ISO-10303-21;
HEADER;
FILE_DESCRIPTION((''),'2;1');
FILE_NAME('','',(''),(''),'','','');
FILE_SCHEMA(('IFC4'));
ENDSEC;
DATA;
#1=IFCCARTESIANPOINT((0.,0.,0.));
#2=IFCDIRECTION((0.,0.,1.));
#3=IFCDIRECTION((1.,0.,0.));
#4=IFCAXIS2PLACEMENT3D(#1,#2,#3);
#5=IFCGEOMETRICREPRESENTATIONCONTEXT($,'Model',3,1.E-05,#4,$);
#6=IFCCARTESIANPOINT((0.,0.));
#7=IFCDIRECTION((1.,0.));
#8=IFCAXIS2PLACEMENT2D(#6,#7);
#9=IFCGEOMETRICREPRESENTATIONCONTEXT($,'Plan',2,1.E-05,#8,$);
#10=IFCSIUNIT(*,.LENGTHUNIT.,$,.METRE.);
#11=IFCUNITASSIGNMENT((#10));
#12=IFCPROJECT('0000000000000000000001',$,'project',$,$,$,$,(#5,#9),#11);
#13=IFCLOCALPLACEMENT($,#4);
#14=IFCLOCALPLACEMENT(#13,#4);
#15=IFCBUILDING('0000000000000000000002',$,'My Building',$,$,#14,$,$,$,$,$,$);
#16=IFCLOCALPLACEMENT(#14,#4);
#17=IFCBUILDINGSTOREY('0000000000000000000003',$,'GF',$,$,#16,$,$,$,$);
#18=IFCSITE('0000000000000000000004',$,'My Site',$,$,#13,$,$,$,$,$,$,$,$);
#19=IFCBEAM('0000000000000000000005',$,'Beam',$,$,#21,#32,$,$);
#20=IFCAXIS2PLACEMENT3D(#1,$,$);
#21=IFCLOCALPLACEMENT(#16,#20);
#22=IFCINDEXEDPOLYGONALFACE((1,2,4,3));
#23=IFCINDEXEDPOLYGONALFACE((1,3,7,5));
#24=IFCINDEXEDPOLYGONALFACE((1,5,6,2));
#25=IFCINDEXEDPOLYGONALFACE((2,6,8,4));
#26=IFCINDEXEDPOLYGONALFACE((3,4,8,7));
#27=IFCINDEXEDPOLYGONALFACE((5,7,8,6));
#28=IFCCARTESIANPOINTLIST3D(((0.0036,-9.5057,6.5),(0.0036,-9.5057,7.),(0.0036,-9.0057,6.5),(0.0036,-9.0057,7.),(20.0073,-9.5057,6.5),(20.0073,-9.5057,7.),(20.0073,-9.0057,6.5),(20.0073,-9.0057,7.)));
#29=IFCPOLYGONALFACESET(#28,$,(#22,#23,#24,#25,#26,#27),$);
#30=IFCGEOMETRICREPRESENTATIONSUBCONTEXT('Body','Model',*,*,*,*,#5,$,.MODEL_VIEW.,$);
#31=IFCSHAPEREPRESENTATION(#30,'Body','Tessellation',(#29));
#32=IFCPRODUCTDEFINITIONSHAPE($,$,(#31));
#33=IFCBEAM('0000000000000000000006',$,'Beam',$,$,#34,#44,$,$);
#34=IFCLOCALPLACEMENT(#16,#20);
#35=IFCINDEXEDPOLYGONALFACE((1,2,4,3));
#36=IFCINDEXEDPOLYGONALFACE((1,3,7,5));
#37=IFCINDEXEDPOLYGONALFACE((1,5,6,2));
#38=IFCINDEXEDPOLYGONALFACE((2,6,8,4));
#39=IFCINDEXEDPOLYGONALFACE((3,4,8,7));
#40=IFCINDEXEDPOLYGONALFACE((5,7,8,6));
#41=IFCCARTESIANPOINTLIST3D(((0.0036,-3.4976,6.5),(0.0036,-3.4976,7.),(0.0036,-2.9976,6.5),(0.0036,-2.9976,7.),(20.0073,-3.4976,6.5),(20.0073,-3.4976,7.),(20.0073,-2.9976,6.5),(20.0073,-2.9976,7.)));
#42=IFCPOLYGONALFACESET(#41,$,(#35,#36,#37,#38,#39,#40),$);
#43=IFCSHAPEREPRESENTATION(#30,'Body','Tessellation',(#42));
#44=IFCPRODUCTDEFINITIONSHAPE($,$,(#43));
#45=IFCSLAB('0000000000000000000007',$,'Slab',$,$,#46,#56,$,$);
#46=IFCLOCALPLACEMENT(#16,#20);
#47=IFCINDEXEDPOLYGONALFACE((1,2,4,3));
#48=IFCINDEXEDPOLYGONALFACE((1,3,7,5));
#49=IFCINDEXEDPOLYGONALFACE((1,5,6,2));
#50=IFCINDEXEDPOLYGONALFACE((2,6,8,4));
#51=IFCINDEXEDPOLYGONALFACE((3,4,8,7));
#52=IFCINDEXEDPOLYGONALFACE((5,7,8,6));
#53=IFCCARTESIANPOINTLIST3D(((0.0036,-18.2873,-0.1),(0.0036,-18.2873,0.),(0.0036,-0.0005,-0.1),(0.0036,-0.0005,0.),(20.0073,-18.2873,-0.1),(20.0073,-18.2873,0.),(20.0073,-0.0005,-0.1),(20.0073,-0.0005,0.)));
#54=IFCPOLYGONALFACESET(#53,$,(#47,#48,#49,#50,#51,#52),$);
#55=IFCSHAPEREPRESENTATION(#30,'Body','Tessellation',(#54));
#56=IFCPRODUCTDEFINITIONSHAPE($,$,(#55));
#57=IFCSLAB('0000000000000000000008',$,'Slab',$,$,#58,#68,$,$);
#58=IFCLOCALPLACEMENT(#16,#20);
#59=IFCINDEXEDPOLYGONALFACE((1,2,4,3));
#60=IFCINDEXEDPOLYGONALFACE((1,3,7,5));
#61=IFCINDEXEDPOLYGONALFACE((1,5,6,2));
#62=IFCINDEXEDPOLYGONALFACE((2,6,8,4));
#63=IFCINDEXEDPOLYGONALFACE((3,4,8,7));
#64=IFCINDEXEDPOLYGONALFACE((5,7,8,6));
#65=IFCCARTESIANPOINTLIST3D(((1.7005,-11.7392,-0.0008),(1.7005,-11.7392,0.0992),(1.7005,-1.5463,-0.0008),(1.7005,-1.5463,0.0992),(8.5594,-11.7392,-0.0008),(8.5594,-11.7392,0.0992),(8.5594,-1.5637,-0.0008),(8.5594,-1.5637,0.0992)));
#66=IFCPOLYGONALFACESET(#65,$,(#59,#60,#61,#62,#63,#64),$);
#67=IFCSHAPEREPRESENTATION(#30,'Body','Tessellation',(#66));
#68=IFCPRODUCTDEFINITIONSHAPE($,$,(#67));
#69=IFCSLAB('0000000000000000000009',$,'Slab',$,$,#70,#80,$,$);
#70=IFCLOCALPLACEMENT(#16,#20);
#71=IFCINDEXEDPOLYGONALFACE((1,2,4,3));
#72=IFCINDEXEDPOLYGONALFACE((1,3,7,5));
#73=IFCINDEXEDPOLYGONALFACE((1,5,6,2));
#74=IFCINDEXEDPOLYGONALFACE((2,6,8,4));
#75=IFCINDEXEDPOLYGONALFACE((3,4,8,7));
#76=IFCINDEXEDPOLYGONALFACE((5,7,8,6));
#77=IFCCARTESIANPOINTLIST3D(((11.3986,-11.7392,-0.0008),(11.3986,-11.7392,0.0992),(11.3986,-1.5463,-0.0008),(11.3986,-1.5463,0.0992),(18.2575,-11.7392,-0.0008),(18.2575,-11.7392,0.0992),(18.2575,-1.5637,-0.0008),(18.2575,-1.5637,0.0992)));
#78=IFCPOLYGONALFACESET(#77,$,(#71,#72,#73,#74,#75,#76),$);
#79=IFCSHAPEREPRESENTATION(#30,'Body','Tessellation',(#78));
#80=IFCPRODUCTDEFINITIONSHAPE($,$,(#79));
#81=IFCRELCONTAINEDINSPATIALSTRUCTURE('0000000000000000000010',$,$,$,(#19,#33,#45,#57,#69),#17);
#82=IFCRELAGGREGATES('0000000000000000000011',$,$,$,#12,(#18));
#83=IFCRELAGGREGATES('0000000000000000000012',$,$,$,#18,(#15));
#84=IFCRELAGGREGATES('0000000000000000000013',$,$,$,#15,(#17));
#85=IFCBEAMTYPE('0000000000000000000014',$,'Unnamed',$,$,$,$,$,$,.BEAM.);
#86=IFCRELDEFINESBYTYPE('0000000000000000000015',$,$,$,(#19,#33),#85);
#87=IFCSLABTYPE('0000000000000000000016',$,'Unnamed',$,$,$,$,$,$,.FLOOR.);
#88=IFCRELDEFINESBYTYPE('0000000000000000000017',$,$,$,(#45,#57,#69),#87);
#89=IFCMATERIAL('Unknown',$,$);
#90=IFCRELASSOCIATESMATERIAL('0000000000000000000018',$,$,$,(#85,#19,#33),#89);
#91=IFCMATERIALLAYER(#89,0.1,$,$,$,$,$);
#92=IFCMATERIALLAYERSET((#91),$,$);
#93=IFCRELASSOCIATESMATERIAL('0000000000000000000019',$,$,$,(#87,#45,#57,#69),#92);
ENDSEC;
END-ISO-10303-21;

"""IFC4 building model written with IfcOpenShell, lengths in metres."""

from ifc_helpers import new_model, si_unit, frame, origin_with_axes, origin_2d_with_axis, place, context, subcontext, project, spatial, indexed_curve, rectangle, outline, extrude, material, layer, layer_set, layer_usage, material_profile, profile_set, profile_usage, type_object, element, save


model = new_model("IFC4")

# Units and contexts
model_context = context("Model", 3, precision=1e-05, world=origin_with_axes())
plan_context = context("Plan", 2, precision=1e-05, world=origin_2d_with_axis())
body_context_1 = subcontext(model_context, "Body", "Model", "MODEL_VIEW")
ifc_project = project(units=[si_unit("LENGTHUNIT", "METRE")], contexts=[model_context, plan_context])

# Site, building, storey
site_placement = place(None, origin_with_axes())
site = spatial("IfcSite", under=ifc_project, at=site_placement, Name="My Site")
building_placement = place(site_placement, origin_with_axes())
building = spatial("IfcBuilding", under=site, at=building_placement, Name="My Building")
storey_placement = place(building_placement, origin_with_axes())
storey = spatial("IfcBuildingStorey", under=building, at=storey_placement, Name="GF")

# Shared definitions
ifc_material = material(Name="Unknown")

# Beams
ifc_material_profile_1 = material_profile(ifc_material, rectangle(XDim=0.5, YDim=0.5))
ifc_profile_set_1 = profile_set([ifc_material_profile_1])
beam_type = type_object("IfcBeamType", Name="Unnamed", PredefinedType="BEAM", material=ifc_profile_set_1)
ifc_profile_usage_1 = profile_usage(ifc_profile_set_1, cardinal=5)
beam_1_placement = place(storey_placement, frame((0.0036, -9.2557, 6.75), z_axis=(1.0, 0.0, 0.0), x_axis=(0.0, 1.0, 0.0)))
element("IfcBeam", 1, at=beam_1_placement, inside=storey, type_object=beam_type, material=ifc_profile_usage_1, Name="Beam", context=body_context_1, shape_type="SweptSolid", body=[
    extrude(rectangle(XDim=0.5, YDim=0.5), origin_with_axes(), (0.0, 0.0, 1.0), 20.0037),
])
ifc_profile_usage_2 = profile_usage(ifc_profile_set_1, cardinal=5)
beam_2_placement = place(storey_placement, frame((0.0036, -3.2476, 6.75), z_axis=(1.0, 0.0, 0.0), x_axis=(0.0, 1.0, 0.0)))
element("IfcBeam", 2, at=beam_2_placement, inside=storey, type_object=beam_type, material=ifc_profile_usage_2, Name="Beam", context=body_context_1, shape_type="SweptSolid", body=[
    extrude(rectangle(XDim=0.5, YDim=0.5), origin_with_axes(), (0.0, 0.0, 1.0), 20.0037),
])

# Slabs
ifc_layer_1 = layer(ifc_material, 0.1)
ifc_layer_set_1 = layer_set([ifc_layer_1])
ifc_layer_usage_1 = layer_usage(ifc_layer_set_1, "AXIS3", "POSITIVE", -0.1)
slab_type = type_object("IfcSlabType", Name="Unnamed", PredefinedType="FLOOR", material=ifc_layer_set_1)
slab_1_placement = place(storey_placement, frame((0.0036, -0.0005, 0.0), z_axis=(0.0, 0.0, 1.0), x_axis=(1.0, 0.0, 0.0)))
element("IfcSlab", 3, at=slab_1_placement, inside=storey, type_object=slab_type, material=ifc_layer_usage_1, Name="Slab", context=body_context_1, shape_type="SweptSolid", body=[
    extrude(outline(indexed_curve([(0.0, 0.0), (0.0, -18.2869), (20.0037, -18.2869), (20.0037, 0.0), (0.0, 0.0)])), frame((0.0, 0.0, -0.1), z_axis=(0.0, 0.0, 1.0), x_axis=(1.0, 0.0, 0.0)), (0.0, 0.0, 1.0), 0.1),
])
ifc_layer_usage_2 = layer_usage(ifc_layer_set_1, "AXIS3", "POSITIVE", -0.1)
slab_2_placement = place(storey_placement, frame((1.7005, -1.5463, 0.0992), z_axis=(0.0, 0.0, 1.0), x_axis=(1.0, 0.0, 0.0)))
element("IfcSlab", 4, at=slab_2_placement, inside=storey, type_object=slab_type, material=ifc_layer_usage_2, Name="Slab", context=body_context_1, shape_type="SweptSolid", body=[
    extrude(outline(indexed_curve([(6.8589, -0.0174), (6.8589, -10.1929), (0.0, -10.1929), (0.0, 0.0), (6.8589, -0.0174)])), frame((0.0, 0.0, -0.1), z_axis=(0.0, 0.0, 1.0), x_axis=(1.0, 0.0, 0.0)), (0.0, 0.0, 1.0), 0.1),
])
ifc_layer_usage_3 = layer_usage(ifc_layer_set_1, "AXIS3", "POSITIVE", -0.1)
slab_3_placement = place(storey_placement, frame((11.3986, -1.5463, 0.0992), z_axis=(0.0, 0.0, 1.0), x_axis=(1.0, 0.0, 0.0)))
element("IfcSlab", 5, at=slab_3_placement, inside=storey, type_object=slab_type, material=ifc_layer_usage_3, Name="Slab", context=body_context_1, shape_type="SweptSolid", body=[
    extrude(outline(indexed_curve([(6.8589, -0.0174), (6.8589, -10.1929), (0.0, -10.1929), (0.0, 0.0), (6.8589, -0.0174)])), frame((0.0, 0.0, -0.1), z_axis=(0.0, 0.0, 1.0), x_axis=(1.0, 0.0, 0.0)), (0.0, 0.0, 1.0), 0.1),
])

save(model, "model.ifc")
